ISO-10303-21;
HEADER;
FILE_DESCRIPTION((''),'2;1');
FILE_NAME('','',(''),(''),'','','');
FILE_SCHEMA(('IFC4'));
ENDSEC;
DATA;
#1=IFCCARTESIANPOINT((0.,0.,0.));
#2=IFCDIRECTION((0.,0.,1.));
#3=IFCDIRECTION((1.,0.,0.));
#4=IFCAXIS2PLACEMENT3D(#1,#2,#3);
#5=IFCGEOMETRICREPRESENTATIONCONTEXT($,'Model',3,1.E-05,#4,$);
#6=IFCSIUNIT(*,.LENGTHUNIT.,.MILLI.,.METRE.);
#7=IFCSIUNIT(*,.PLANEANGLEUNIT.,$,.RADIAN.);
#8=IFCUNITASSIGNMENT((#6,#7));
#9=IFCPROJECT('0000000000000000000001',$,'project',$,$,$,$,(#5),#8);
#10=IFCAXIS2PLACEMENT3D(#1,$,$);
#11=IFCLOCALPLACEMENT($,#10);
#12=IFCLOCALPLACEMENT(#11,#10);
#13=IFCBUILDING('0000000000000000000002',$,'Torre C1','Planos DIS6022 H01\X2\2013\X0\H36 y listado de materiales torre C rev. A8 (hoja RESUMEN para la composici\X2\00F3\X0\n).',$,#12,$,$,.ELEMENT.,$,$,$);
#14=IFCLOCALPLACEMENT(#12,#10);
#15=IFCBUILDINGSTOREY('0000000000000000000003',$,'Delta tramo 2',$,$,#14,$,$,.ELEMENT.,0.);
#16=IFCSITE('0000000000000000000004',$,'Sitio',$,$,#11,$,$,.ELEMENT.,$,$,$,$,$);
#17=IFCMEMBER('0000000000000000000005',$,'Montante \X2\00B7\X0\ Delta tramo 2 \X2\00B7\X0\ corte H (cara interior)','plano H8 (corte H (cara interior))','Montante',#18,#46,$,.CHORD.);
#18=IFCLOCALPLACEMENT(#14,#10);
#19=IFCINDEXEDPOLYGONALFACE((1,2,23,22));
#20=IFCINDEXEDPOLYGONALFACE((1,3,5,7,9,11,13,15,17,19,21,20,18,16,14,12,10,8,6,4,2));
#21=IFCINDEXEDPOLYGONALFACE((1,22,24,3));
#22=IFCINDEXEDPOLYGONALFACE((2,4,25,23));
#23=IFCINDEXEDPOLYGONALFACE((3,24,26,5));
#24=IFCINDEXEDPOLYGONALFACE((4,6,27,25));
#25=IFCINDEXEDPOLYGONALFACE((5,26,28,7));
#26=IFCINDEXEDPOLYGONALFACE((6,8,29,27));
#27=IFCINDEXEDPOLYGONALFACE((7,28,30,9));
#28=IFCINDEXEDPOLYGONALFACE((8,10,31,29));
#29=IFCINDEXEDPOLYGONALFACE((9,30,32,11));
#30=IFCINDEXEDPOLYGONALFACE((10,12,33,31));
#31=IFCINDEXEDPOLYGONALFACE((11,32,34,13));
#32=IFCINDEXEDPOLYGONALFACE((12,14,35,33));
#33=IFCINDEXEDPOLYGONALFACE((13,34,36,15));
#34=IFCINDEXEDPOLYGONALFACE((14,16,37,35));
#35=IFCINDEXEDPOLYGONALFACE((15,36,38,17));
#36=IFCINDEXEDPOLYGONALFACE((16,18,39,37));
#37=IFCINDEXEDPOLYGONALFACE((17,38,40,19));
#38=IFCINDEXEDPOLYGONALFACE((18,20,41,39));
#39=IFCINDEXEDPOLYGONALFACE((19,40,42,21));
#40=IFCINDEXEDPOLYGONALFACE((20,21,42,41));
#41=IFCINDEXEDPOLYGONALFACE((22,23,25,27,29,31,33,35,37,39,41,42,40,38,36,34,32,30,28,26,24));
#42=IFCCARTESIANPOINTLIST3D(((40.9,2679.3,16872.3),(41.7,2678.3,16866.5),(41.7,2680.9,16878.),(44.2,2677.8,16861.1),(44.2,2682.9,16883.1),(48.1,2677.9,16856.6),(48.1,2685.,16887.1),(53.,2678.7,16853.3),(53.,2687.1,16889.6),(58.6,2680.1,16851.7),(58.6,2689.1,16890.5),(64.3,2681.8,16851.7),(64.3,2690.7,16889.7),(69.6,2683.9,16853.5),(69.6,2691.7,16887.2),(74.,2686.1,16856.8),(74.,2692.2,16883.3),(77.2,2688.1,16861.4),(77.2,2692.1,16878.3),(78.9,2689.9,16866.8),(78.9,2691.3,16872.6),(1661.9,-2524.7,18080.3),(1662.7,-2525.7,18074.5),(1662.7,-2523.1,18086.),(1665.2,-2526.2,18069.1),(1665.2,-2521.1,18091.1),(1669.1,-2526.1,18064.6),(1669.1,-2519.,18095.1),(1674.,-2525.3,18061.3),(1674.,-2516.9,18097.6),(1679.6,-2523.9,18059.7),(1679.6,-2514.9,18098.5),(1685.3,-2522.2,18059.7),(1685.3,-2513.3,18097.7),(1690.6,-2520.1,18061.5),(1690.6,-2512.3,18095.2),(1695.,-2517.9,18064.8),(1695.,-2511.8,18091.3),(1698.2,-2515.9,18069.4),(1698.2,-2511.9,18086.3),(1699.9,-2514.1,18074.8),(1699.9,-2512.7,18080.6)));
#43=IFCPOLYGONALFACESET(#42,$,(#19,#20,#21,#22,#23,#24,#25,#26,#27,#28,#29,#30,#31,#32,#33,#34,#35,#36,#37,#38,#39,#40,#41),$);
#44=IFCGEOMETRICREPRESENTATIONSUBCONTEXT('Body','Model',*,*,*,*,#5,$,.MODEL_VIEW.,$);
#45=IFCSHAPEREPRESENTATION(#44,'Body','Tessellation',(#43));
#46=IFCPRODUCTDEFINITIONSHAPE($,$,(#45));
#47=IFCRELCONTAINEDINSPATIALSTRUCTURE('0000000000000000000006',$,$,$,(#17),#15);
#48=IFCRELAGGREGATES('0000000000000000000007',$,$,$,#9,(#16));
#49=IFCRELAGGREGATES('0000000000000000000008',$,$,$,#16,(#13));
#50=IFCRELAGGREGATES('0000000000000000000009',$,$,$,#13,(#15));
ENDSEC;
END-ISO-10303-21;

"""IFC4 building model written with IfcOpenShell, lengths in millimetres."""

from ifc_helpers import new_model, si_unit, frame, origin, origin_with_axes, place, context, subcontext, project, spatial, circle, extrude, element, save


model = new_model("IFC4")

# Units and contexts
model_context = context("Model", 3, precision=1e-05, world=origin_with_axes())
body_context = subcontext(model_context, "Body", "Model", "MODEL_VIEW")
ifc_project = project(units=[si_unit("LENGTHUNIT", "METRE", prefix="MILLI"), si_unit("PLANEANGLEUNIT", "RADIAN")], contexts=[model_context])

# Site, building, storey
site_placement = place(None, origin())
site = spatial("IfcSite", under=ifc_project, at=site_placement, Name="Sitio", CompositionType="ELEMENT")
building_placement = place(site_placement, origin())
building = spatial("IfcBuilding", under=site, at=building_placement, Name="Torre C1", Description="Planos DIS6022 H01–H36 y listado de materiales torre C rev. A8 (hoja RESUMEN para la composición).", CompositionType="ELEMENT")
storey_placement = place(building_placement, origin())
storey = spatial("IfcBuildingStorey", under=building, at=storey_placement, Name="Delta tramo 2", CompositionType="ELEMENT", Elevation=0.0)

# Member
member_1_placement = place(storey_placement, frame((60.0, 2685.0, 16871.0), z_axis=(0.290352, -0.932136, 0.216376), x_axis=(-0.95692, -0.282832, 0.065654)))
element("IfcMember", 1, at=member_1_placement, inside=storey, Name="Montante · Delta tramo 2 · corte H (cara interior)", Description="plano H8 (corte H (cara interior))", ObjectType="Montante", PredefinedType="CHORD", context=body_context, shape_type="SweptSolid", body=[
    extrude(circle(Radius=20.0), None, (0.0, 0.0, 1.0), 5582.9),
])

save(model, "model.ifc")
